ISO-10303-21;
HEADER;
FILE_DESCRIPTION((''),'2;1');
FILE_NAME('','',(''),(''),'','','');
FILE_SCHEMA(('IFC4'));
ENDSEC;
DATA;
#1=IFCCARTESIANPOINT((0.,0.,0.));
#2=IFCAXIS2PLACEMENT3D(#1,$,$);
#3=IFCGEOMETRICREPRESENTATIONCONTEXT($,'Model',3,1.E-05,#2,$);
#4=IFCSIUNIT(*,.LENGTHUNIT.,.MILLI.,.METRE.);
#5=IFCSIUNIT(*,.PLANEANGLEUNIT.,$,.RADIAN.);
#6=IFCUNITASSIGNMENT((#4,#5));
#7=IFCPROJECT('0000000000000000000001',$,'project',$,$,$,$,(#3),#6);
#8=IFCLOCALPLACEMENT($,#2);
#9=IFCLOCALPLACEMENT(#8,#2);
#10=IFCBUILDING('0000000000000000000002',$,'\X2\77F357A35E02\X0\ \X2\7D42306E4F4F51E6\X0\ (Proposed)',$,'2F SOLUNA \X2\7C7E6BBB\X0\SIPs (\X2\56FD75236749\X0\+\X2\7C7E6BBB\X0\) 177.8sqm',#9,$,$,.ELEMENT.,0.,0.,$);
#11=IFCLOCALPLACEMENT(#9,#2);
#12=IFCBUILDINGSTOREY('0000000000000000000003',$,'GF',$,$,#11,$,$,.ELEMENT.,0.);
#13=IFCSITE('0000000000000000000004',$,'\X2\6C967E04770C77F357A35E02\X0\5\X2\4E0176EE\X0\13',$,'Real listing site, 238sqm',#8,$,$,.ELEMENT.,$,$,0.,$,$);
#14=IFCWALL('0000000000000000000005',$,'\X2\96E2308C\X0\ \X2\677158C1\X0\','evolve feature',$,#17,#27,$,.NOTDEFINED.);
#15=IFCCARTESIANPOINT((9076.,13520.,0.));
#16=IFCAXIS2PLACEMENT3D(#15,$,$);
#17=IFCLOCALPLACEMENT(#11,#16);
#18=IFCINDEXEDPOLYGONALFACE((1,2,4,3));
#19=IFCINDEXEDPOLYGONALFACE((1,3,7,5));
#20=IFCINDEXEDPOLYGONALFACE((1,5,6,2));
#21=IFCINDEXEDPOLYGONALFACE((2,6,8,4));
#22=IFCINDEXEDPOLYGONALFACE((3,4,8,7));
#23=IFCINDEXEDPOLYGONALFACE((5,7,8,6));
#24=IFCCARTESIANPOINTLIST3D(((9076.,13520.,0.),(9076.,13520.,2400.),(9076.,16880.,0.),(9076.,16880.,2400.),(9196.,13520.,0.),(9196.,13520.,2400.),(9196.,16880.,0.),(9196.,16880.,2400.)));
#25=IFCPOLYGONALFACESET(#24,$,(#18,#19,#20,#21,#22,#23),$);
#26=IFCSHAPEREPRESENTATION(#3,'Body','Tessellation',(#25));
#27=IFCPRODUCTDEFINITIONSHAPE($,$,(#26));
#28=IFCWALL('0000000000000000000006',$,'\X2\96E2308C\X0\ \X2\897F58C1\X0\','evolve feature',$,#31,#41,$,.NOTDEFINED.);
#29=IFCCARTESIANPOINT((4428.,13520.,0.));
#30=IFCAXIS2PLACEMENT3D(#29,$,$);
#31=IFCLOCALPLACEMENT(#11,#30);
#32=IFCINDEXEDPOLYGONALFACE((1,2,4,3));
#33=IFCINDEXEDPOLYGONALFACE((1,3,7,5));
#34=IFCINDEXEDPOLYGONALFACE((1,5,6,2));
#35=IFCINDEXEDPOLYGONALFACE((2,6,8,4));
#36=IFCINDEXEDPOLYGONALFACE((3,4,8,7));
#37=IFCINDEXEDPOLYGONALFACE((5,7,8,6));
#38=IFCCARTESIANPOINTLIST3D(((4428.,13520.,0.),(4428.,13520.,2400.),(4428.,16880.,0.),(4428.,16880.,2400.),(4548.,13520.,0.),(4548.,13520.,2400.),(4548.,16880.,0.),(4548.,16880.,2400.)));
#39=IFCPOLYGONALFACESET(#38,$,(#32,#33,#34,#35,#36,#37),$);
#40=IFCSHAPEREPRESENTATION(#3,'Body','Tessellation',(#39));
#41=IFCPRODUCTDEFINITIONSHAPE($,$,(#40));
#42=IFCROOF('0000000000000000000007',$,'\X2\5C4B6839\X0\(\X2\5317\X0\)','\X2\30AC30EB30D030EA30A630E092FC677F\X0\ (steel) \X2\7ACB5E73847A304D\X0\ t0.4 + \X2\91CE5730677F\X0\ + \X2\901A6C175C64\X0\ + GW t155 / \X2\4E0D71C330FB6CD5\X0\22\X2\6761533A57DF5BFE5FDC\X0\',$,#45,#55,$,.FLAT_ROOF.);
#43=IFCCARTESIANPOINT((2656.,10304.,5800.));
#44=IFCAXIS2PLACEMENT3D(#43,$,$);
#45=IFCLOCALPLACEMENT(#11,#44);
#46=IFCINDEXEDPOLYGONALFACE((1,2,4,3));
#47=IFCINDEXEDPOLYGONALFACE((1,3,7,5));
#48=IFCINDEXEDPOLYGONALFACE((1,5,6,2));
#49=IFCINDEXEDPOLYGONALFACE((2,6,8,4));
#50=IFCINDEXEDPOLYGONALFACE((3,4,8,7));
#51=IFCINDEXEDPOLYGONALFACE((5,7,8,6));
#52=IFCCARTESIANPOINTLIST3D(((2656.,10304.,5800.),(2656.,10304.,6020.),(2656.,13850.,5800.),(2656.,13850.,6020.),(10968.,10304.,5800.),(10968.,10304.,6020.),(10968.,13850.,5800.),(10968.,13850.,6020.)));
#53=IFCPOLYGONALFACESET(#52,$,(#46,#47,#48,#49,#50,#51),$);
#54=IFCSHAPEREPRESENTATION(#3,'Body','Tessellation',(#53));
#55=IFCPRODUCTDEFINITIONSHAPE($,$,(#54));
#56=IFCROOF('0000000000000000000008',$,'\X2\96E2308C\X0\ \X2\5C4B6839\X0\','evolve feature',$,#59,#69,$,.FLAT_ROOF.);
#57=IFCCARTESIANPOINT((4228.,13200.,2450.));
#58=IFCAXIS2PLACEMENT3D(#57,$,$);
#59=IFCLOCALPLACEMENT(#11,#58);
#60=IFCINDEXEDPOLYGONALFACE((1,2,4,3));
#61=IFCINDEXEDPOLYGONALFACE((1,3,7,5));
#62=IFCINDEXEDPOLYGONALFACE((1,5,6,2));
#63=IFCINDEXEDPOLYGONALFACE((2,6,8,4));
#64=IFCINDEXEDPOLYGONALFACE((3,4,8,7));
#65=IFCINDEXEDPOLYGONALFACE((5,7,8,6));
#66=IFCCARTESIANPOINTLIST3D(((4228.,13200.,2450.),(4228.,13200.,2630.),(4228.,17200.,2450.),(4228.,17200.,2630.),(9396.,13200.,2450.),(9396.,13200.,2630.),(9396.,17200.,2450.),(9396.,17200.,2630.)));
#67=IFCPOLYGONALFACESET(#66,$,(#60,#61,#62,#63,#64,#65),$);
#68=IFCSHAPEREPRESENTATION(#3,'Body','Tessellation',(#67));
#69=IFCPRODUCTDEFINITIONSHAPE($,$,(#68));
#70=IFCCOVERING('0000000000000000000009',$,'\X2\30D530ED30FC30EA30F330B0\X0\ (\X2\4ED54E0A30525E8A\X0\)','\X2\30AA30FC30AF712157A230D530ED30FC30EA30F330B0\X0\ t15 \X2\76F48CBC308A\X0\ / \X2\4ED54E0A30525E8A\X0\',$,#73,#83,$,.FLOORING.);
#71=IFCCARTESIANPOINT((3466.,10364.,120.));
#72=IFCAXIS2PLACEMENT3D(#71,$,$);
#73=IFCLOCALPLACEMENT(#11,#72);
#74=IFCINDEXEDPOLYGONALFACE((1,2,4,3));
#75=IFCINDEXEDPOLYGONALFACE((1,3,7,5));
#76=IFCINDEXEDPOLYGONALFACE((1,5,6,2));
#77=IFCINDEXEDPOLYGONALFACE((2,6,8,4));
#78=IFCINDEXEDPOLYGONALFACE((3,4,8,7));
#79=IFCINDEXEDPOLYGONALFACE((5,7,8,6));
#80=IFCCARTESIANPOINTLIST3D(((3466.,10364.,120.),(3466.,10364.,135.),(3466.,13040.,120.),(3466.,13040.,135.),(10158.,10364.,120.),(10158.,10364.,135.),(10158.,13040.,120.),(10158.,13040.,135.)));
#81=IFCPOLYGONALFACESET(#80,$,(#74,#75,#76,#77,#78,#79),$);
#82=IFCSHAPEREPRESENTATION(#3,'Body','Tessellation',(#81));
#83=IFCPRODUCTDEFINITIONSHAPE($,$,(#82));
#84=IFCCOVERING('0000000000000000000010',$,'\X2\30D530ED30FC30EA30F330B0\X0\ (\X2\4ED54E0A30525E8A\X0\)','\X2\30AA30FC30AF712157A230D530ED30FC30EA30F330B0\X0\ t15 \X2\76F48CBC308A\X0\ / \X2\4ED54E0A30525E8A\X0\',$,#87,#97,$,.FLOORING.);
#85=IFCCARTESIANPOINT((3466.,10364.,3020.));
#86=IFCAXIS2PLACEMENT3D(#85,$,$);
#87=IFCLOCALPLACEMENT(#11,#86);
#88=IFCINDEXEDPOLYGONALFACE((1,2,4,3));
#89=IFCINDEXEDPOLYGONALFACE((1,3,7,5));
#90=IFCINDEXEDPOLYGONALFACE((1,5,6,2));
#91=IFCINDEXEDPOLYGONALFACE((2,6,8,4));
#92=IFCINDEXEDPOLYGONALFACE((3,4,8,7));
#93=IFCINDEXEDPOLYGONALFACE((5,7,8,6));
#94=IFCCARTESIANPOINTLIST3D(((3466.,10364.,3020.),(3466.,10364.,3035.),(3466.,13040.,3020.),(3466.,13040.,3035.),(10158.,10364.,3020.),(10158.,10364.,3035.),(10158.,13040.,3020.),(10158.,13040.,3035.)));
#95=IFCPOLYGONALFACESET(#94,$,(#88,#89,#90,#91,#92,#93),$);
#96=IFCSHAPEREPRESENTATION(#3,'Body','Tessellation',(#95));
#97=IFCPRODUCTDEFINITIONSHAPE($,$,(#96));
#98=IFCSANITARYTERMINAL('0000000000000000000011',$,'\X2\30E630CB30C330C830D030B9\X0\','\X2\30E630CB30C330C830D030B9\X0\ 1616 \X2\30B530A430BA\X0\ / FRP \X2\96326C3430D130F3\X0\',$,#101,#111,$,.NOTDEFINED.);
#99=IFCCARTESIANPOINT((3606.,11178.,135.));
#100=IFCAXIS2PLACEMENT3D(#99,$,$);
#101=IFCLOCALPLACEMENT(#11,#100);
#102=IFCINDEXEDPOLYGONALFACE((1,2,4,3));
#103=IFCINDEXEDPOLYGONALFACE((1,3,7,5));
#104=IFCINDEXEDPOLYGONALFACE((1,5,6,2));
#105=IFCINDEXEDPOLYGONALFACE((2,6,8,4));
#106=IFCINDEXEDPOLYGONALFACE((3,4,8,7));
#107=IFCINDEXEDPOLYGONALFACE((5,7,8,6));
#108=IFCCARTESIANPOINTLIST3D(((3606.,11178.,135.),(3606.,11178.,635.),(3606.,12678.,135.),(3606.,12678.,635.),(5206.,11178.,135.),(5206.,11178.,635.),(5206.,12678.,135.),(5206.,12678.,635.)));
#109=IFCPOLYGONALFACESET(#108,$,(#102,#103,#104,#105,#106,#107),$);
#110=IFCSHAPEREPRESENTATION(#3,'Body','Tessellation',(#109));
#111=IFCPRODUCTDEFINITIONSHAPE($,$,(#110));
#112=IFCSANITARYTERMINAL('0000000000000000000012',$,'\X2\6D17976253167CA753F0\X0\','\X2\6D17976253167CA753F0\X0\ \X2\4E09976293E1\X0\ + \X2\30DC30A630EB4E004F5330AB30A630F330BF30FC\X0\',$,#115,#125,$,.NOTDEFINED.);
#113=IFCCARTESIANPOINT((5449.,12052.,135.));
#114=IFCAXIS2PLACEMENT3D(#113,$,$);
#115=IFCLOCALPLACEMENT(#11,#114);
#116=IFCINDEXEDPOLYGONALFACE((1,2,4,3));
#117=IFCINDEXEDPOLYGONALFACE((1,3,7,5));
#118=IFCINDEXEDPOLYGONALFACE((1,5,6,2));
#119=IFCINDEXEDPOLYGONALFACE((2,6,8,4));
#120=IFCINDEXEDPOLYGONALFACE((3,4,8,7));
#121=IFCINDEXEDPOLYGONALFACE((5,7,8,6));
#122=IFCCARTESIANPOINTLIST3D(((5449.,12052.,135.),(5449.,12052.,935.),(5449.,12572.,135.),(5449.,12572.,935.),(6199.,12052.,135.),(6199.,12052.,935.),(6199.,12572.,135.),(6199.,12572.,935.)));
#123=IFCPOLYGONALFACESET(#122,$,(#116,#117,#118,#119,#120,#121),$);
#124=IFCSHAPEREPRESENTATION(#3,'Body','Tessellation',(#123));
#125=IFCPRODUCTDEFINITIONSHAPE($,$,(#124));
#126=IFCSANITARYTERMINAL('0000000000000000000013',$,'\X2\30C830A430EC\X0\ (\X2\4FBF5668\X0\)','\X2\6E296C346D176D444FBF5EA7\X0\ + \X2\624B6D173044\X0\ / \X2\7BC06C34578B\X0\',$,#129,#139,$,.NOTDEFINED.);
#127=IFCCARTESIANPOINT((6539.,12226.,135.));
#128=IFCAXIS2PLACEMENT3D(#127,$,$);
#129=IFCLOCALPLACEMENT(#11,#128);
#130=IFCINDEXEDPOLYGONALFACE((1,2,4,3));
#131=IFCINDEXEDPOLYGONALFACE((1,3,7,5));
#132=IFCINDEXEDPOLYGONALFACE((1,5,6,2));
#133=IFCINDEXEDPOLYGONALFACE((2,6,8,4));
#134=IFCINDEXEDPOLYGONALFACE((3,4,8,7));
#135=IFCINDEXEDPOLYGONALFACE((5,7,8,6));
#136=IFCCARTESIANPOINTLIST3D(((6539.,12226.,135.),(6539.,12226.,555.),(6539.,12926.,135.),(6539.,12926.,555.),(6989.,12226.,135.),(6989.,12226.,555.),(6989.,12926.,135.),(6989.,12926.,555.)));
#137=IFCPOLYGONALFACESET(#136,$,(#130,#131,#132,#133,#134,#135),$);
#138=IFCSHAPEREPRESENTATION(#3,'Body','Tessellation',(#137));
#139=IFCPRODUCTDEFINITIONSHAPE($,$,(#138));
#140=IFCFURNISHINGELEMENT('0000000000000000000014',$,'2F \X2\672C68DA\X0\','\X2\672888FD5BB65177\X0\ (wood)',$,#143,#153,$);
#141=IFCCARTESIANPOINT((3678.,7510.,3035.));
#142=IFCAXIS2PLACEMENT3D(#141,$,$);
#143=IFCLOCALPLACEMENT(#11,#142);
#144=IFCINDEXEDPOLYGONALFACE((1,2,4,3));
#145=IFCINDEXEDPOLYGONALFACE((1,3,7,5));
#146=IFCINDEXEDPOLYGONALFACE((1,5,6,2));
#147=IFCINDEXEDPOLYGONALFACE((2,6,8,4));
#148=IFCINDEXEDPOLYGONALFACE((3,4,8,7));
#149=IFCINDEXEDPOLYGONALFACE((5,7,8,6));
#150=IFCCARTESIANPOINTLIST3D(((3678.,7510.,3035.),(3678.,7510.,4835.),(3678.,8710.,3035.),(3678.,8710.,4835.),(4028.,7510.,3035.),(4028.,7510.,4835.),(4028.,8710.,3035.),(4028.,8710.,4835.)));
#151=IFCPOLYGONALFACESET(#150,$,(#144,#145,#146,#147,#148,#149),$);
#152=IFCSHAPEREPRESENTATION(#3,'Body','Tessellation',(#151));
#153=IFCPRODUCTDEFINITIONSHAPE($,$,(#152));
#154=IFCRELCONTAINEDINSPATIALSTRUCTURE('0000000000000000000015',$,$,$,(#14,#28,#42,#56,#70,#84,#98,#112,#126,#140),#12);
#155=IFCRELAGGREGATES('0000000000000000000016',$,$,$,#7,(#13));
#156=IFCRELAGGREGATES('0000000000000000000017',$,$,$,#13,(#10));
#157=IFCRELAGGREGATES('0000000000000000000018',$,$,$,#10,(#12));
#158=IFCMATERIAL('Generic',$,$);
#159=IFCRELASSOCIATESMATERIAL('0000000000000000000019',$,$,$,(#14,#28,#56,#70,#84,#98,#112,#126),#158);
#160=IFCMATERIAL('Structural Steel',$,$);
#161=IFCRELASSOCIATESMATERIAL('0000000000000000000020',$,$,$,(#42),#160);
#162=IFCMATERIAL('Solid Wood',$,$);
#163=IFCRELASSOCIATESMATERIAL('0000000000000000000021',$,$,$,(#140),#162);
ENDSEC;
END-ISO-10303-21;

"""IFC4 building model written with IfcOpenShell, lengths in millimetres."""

from ifc_helpers import new_model, si_unit, frame, frame_2d, origin, place, context, project, spatial, rectangle, extrude, material, element, save


model = new_model("IFC4")

# Units and contexts
model_context = context("Model", 3, precision=1e-05, world=origin())
ifc_project = project(units=[si_unit("LENGTHUNIT", "METRE", prefix="MILLI"), si_unit("PLANEANGLEUNIT", "RADIAN")], contexts=[model_context])

# Site, building, storey
site_placement = place(None, origin())
site = spatial("IfcSite", under=ifc_project, at=site_placement, Name="沖縄県石垣市5丁目13", ObjectType="Real listing site, 238sqm", CompositionType="ELEMENT", RefElevation=0.0)
building_placement = place(site_placement, origin())
building = spatial("IfcBuilding", under=site, at=building_placement, Name="石垣市 終の住処 (Proposed)", ObjectType="2F SOLUNA 籾殻SIPs (国産杉+籾殻) 177.8sqm", CompositionType="ELEMENT", ElevationOfRefHeight=0.0, ElevationOfTerrain=0.0)
storey_placement = place(building_placement, origin())
storey = spatial("IfcBuildingStorey", under=building, at=storey_placement, Name="GF", CompositionType="ELEMENT", Elevation=0.0)

# Shared definitions
ifc_material_1 = material(Name="Solid Wood")
ifc_material_2 = material(Name="Generic")

# Walls
wall_1_placement = place(storey_placement, frame((9076.0, 13520.0, 0.0)))
element("IfcWall", 1, at=wall_1_placement, inside=storey, material=ifc_material_2, Name="離れ 東壁", Description="evolve feature", PredefinedType="NOTDEFINED", context=model_context, shape_type="SweptSolid", body=[
    extrude(rectangle(XDim=120.0, YDim=3360.0, at=frame_2d((60.0, 1680.0))), frame((9076.0, 13520.0, 0.0)), (0.0, 0.0, 1.0), 2400.0),
])
wall_2_placement = place(storey_placement, frame((4428.0, 13520.0, 0.0)))
element("IfcWall", 2, at=wall_2_placement, inside=storey, material=ifc_material_2, Name="離れ 西壁", Description="evolve feature", PredefinedType="NOTDEFINED", context=model_context, shape_type="SweptSolid", body=[
    extrude(rectangle(XDim=120.0, YDim=3360.0, at=frame_2d((60.0, 1680.0))), frame((4428.0, 13520.0, 0.0)), (0.0, 0.0, 1.0), 2400.0),
])

# Roofs
ifc_material_3 = material(Name="Structural Steel")
for number, where, name in (
    (3, (2656.0, 10304.0, 5800.0), "屋根(北)"),
):
    element("IfcRoof", number, at=place(storey_placement, frame(where)), inside=storey, material=ifc_material_3, Name=name, Description="ガルバリウム鋼板 (steel) 立平葺き t0.4 + 野地板 + 通気層 + GW t155 / 不燃・法22条区域対応", PredefinedType="FLAT_ROOF", context=model_context, shape_type="SweptSolid", body=[
        extrude(rectangle(XDim=8312.0, YDim=3546.0, at=frame_2d((4156.0, 1773.0))), frame((2656.0, 10304.0, 5800.0)), (0.0, 0.0, 1.0), 220.0),
    ])
roof_1_placement = place(storey_placement, frame((4228.0, 13200.0, 2450.0)))
element("IfcRoof", 4, at=roof_1_placement, inside=storey, material=ifc_material_2, Name="離れ 屋根", Description="evolve feature", PredefinedType="FLAT_ROOF", context=model_context, shape_type="SweptSolid", body=[
    extrude(rectangle(XDim=5168.0, YDim=4000.0, at=frame_2d((2584.0, 2000.0))), frame((4228.0, 13200.0, 2450.0)), (0.0, 0.0, 1.0), 180.0),
])

# Coverings
covering_1_placement = place(storey_placement, frame((3466.0, 10364.0, 120.0)))
element("IfcCovering", 5, at=covering_1_placement, inside=storey, material=ifc_material_2, Name="フローリング (仕上げ床)", Description="オーク無垢フローリング t15 直貼り / 仕上げ床", PredefinedType="FLOORING", context=model_context, shape_type="SweptSolid", body=[
    extrude(rectangle(XDim=6692.0, YDim=2676.0, at=frame_2d((3346.0, 1338.0))), frame((3466.0, 10364.0, 120.0)), (0.0, 0.0, 1.0), 15.0),
])
covering_2_placement = place(storey_placement, frame((3466.0, 10364.0, 3020.0)))
element("IfcCovering", 6, at=covering_2_placement, inside=storey, material=ifc_material_2, Name="フローリング (仕上げ床)", Description="オーク無垢フローリング t15 直貼り / 仕上げ床", PredefinedType="FLOORING", context=model_context, shape_type="SweptSolid", body=[
    extrude(rectangle(XDim=6692.0, YDim=2676.0, at=frame_2d((3346.0, 1338.0))), frame((3466.0, 10364.0, 3020.0)), (0.0, 0.0, 1.0), 15.0),
])

# Sanitary terminals
sanitary_terminal_1_placement = place(storey_placement, frame((3606.0, 11178.0, 135.0)))
element("IfcSanitaryTerminal", 7, at=sanitary_terminal_1_placement, inside=storey, material=ifc_material_2, Name="ユニットバス", Description="ユニットバス 1616 サイズ / FRP 防水パン", PredefinedType="NOTDEFINED", context=model_context, shape_type="SweptSolid", body=[
    extrude(rectangle(XDim=1600.0, YDim=1500.0, at=frame_2d((800.0, 750.0))), frame((3606.0, 11178.0, 135.0)), (0.0, 0.0, 1.0), 500.0),
])
sanitary_terminal_2_placement = place(storey_placement, frame((5449.0, 12052.0, 135.0)))
element("IfcSanitaryTerminal", 8, at=sanitary_terminal_2_placement, inside=storey, material=ifc_material_2, Name="洗面化粧台", Description="洗面化粧台 三面鏡 + ボウル一体カウンター", PredefinedType="NOTDEFINED", context=model_context, shape_type="SweptSolid", body=[
    extrude(rectangle(XDim=750.0, YDim=520.0, at=frame_2d((375.0, 260.0))), frame((5449.0, 12052.0, 135.0)), (0.0, 0.0, 1.0), 800.0),
])
sanitary_terminal_3_placement = place(storey_placement, frame((6539.0, 12226.0, 135.0)))
element("IfcSanitaryTerminal", 9, at=sanitary_terminal_3_placement, inside=storey, material=ifc_material_2, Name="トイレ (便器)", Description="温水洗浄便座 + 手洗い / 節水型", PredefinedType="NOTDEFINED", context=model_context, shape_type="SweptSolid", body=[
    extrude(rectangle(XDim=450.0, YDim=700.0, at=frame_2d((225.0, 350.0))), frame((6539.0, 12226.0, 135.0)), (0.0, 0.0, 1.0), 420.0),
])

# Furnishing element
furnishing_placement = place(storey_placement, frame((3678.0, 7510.0, 3035.0)))
element("IfcFurnishingElement", 10, at=furnishing_placement, inside=storey, material=ifc_material_1, Name="2F 本棚", Description="木製家具 (wood)", context=model_context, shape_type="SweptSolid", body=[
    extrude(rectangle(XDim=350.0, YDim=1200.0, at=frame_2d((175.0, 600.0))), frame((3678.0, 7510.0, 3035.0)), (0.0, 0.0, 1.0), 1800.0),
])

save(model, "model.ifc")
